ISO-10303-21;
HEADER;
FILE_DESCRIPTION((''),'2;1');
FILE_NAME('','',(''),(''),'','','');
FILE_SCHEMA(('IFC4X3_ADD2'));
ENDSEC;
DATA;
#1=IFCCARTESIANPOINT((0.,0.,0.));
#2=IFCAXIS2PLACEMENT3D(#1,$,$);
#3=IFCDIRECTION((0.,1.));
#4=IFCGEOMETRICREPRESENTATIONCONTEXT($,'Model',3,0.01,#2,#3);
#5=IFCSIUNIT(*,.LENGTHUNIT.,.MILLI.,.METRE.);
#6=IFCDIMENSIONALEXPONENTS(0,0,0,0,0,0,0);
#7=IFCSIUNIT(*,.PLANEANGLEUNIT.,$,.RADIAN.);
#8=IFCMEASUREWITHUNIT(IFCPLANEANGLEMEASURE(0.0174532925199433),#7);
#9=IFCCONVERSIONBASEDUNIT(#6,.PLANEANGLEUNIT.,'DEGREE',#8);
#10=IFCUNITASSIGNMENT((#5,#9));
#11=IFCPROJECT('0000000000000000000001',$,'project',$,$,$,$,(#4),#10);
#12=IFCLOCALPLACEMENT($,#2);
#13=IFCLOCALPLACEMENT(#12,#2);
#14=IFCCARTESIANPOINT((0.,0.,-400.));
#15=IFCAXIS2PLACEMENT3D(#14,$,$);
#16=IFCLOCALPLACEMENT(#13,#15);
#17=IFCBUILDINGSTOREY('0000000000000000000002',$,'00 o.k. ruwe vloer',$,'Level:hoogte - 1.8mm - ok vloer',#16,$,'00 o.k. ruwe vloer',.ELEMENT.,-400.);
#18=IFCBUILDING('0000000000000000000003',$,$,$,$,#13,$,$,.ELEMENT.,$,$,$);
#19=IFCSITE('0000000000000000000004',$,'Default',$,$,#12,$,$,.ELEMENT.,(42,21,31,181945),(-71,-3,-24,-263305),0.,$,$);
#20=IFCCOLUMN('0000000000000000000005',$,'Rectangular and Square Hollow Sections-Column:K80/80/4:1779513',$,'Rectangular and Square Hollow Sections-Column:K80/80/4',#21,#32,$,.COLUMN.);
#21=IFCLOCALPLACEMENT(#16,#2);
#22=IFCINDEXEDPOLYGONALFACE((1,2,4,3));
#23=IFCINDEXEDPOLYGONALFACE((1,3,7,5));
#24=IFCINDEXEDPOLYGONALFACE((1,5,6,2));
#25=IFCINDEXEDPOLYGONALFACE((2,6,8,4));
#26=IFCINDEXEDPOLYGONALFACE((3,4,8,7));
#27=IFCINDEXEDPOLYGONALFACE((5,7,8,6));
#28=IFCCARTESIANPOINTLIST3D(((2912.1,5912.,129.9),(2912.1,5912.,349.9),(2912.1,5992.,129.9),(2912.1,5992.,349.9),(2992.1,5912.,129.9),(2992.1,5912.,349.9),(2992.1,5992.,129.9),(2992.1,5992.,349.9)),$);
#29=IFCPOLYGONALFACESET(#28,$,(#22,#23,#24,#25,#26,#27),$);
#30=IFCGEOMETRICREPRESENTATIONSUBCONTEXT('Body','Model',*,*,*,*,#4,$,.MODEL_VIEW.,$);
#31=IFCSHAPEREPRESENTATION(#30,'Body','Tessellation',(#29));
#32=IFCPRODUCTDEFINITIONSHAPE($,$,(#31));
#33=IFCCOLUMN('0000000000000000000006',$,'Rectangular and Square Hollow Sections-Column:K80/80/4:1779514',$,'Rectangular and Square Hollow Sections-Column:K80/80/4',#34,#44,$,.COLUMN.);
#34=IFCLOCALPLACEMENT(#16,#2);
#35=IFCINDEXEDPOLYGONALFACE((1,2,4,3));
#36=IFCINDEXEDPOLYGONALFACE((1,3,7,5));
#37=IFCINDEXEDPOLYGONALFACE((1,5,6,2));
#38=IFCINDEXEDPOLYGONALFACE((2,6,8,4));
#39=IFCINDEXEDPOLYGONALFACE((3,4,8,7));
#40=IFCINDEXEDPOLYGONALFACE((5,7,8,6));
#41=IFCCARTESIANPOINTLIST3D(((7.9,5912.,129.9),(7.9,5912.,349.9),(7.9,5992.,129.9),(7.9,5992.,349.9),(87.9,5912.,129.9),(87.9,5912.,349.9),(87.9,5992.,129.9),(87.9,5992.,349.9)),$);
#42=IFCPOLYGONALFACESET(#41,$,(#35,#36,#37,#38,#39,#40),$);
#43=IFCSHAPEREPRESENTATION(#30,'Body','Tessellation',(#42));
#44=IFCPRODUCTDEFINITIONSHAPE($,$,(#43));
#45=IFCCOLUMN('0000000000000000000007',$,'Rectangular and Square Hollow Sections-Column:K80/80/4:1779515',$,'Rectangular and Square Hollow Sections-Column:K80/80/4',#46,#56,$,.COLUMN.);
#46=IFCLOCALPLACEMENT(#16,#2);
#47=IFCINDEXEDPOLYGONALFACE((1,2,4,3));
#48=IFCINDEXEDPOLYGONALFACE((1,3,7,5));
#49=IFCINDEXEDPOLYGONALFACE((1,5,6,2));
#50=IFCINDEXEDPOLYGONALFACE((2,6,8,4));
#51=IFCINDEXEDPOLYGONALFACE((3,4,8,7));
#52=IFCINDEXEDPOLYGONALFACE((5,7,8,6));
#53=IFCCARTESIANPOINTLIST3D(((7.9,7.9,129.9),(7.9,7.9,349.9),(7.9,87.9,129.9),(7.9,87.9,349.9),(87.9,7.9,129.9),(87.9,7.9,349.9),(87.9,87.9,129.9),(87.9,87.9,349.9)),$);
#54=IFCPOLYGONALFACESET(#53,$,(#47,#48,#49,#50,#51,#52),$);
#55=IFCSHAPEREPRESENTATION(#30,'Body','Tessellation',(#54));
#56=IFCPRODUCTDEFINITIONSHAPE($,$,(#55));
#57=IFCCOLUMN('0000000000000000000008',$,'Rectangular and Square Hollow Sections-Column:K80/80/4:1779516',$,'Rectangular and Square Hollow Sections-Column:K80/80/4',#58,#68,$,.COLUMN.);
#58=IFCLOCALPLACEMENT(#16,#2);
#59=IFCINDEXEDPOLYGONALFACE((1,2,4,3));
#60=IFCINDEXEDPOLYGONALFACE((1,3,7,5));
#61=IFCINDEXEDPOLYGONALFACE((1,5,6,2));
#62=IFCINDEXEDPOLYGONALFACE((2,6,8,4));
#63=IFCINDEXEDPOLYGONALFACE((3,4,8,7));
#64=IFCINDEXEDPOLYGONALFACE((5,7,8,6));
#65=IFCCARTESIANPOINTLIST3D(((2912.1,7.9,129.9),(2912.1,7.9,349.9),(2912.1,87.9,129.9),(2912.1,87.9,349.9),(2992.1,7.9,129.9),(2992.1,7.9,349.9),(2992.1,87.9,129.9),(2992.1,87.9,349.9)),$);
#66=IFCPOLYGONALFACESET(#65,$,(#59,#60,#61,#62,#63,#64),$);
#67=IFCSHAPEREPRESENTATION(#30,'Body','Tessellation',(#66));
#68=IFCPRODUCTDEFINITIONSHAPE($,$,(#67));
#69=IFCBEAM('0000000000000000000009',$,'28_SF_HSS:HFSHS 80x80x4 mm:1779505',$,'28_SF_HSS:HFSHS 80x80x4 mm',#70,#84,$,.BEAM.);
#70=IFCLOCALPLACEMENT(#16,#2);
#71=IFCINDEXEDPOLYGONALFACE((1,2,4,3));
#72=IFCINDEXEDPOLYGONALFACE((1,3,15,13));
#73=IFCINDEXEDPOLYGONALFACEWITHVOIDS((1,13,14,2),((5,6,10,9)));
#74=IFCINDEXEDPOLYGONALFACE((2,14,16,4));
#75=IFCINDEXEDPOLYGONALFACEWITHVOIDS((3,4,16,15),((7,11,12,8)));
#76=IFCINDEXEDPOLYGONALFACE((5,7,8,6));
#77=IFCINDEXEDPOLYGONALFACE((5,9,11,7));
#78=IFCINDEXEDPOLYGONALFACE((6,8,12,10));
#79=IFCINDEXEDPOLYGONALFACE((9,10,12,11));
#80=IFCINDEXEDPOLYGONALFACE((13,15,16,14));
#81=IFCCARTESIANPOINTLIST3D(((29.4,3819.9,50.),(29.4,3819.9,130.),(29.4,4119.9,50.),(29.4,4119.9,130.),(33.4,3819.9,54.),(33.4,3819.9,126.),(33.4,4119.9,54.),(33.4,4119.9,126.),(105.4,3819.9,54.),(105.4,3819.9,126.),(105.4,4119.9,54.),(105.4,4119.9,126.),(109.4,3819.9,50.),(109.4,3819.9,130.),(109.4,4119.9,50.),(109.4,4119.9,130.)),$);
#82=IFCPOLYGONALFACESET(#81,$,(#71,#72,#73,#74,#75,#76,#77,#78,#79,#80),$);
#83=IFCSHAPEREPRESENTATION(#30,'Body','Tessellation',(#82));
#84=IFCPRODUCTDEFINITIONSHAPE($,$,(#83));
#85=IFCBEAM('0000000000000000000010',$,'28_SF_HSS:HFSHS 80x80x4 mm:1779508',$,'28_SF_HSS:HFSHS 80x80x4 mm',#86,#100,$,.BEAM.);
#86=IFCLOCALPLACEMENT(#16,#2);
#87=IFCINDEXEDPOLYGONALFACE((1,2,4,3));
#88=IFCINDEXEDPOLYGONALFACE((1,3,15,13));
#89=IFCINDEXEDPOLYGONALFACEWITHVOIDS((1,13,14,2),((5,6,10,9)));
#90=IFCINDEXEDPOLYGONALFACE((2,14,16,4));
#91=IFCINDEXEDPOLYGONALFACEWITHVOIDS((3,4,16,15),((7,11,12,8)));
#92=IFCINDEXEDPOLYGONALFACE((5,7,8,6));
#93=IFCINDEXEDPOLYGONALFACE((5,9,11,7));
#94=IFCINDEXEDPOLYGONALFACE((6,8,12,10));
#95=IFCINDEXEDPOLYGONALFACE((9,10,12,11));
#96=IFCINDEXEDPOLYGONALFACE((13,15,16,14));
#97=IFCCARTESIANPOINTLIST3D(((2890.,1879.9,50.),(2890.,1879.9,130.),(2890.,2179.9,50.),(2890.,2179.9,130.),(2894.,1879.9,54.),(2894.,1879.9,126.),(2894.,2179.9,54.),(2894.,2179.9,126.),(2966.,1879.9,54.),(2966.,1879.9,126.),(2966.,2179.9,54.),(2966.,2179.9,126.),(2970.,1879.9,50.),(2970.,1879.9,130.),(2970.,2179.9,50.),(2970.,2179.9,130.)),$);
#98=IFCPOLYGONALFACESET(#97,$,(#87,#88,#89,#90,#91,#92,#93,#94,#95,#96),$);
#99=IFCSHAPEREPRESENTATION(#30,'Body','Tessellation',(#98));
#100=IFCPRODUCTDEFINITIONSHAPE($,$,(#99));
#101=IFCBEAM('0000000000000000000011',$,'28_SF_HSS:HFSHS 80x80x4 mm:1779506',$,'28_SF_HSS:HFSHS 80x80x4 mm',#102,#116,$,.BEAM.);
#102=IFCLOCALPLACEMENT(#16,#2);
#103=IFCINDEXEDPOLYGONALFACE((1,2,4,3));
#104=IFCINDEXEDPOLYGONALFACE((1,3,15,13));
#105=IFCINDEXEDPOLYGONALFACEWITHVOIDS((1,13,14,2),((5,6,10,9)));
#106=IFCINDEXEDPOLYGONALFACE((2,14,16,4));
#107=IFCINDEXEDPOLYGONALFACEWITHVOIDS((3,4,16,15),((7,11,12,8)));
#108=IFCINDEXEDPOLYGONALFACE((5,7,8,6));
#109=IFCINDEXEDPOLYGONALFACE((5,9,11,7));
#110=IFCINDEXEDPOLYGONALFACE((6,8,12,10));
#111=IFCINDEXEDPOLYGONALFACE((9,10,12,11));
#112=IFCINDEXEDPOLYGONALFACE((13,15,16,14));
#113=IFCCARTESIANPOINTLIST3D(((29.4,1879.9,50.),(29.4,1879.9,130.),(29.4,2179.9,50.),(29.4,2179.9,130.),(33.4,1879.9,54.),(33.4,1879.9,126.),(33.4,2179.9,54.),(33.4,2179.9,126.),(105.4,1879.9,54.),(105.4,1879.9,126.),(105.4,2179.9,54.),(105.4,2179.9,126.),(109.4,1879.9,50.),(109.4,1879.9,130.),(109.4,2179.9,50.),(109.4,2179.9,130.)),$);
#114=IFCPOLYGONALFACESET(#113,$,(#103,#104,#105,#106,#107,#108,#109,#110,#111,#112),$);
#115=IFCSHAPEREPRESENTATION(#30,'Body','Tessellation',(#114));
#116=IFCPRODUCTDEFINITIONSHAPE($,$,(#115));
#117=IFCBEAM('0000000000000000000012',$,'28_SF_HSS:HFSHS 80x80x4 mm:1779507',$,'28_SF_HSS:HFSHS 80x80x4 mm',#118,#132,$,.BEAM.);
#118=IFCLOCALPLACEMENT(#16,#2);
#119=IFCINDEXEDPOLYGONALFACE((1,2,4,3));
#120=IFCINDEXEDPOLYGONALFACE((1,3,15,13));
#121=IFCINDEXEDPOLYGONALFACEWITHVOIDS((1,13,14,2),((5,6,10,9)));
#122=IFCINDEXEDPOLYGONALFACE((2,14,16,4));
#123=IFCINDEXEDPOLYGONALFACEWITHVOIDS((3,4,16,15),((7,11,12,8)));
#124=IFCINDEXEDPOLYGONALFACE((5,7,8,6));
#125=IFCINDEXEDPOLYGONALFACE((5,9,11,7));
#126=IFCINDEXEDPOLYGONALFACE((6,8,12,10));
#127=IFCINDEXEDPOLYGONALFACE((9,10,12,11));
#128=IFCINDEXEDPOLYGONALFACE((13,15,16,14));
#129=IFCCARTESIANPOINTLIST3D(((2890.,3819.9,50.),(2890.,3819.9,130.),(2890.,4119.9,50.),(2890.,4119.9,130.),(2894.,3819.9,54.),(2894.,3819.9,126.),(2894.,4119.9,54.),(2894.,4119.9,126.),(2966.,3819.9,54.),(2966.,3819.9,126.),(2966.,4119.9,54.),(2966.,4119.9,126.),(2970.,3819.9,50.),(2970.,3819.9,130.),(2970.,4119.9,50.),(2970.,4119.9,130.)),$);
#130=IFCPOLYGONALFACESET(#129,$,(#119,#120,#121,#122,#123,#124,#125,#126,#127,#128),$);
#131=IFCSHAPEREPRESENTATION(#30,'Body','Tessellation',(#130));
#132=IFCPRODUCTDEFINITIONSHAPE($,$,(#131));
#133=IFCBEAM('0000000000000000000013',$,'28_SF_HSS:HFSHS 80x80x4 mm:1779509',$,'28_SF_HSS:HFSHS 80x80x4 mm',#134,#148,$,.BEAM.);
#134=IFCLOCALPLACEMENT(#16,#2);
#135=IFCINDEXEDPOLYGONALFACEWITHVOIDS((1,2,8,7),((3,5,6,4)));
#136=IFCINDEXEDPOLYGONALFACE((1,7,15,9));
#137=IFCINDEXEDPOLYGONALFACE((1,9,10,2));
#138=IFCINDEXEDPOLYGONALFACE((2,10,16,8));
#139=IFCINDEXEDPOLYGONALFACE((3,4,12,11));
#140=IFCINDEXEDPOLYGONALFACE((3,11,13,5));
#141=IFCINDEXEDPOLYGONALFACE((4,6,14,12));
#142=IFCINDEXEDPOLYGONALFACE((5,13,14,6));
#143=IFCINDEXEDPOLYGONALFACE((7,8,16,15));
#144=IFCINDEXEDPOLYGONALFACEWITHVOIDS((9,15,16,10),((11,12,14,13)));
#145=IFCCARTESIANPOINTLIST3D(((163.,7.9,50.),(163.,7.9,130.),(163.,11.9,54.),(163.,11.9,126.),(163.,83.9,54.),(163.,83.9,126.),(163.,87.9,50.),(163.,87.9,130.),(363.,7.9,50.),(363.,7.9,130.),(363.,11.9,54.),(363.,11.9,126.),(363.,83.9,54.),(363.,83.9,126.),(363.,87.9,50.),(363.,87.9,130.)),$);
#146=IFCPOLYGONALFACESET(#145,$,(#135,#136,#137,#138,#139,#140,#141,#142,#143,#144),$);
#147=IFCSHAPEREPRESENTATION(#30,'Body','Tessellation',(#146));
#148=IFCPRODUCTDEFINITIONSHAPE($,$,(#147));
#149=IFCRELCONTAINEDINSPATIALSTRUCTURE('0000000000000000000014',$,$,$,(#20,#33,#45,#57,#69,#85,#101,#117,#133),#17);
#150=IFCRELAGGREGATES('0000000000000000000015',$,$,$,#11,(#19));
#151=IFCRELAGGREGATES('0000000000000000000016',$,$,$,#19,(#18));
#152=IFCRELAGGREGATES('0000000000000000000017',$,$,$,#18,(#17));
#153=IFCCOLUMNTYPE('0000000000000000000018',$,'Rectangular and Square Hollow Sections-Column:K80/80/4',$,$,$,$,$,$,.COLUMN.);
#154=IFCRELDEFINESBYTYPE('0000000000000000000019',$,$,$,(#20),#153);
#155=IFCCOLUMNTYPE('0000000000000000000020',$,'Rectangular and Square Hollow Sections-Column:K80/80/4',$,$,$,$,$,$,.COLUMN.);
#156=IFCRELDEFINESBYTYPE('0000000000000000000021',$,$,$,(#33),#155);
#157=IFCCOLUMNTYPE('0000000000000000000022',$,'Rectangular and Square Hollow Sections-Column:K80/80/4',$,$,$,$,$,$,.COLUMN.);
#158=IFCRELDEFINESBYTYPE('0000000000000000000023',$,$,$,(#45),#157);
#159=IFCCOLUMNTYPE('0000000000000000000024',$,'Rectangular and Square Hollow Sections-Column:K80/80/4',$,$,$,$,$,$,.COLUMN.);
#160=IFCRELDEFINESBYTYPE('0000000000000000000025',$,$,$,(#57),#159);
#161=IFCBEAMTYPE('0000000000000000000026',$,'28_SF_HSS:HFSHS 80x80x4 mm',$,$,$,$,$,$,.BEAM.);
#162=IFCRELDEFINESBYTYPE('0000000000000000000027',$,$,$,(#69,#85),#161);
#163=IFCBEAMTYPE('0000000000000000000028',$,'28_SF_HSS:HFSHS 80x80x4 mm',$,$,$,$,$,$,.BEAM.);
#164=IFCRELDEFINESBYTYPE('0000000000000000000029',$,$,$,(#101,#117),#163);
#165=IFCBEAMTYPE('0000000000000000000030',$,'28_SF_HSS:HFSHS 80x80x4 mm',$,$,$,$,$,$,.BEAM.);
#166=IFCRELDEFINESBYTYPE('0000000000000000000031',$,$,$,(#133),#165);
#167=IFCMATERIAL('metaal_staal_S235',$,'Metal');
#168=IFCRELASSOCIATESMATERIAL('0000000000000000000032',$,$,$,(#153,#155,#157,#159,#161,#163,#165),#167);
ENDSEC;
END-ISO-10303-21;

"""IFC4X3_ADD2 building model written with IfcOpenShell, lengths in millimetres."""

from ifc_helpers import new_model, entity, si_unit, converted_unit, direction, frame, frame_2d, origin, origin_2d_with_axis, place, context, subcontext, project, spatial, polyline, rectangle, outline, extrude, source, transform, mapped, material, material_profile, profile_set, type_object, type_shapes, element, save


model = new_model("IFC4X3_ADD2")

# Units and contexts
model_context = context("Model", 3, precision=0.01, world=origin(), true_north=direction((0.0, 1.0)))
body_context = subcontext(model_context, "Body", "Model", "MODEL_VIEW")
ifc_project = project(units=[si_unit("LENGTHUNIT", "METRE", prefix="MILLI"), converted_unit("PLANEANGLEUNIT", "DEGREE", entity("IfcPlaneAngleMeasure", 0.0174532925199433), si_unit("PLANEANGLEUNIT", "RADIAN"), dimensions=[0, 0, 0, 0, 0, 0, 0])], contexts=[model_context])

# Site, building, storey
site_placement = place(None, origin())
site = spatial("IfcSite", under=ifc_project, at=site_placement, Name="Default", CompositionType="ELEMENT", RefLatitude=(42, 21, 31, 181945), RefLongitude=(-71, -3, -24, -263305), RefElevation=0.0)
building_placement = place(site_placement, origin())
building = spatial("IfcBuilding", under=site, at=building_placement, CompositionType="ELEMENT")
storey_placement = place(building_placement, frame((0.0, 0.0, -400.0)))
storey = spatial("IfcBuildingStorey", under=building, at=storey_placement, Name="00 o.k. ruwe vloer", ObjectType="Level:hoogte - 1.8mm - ok vloer", LongName="00 o.k. ruwe vloer", CompositionType="ELEMENT", Elevation=-400.0)

# Columns, openings
ifc_material = material(Name="metaal_staal_S235", Category="Metal")
ifc_material_profile_1 = material_profile(ifc_material, rectangle(XDim=220.0, YDim=80.0, at=frame_2d((0.0, 0.0), x_axis=(1.0, 0.0))), Name="K80/80/4")
ifc_profile_set_1 = profile_set([ifc_material_profile_1], Name="K80/80/4")
column_type_1 = type_object("IfcColumnType", Name="Rectangular and Square Hollow Sections-Column:K80/80/4", PredefinedType="COLUMN", material=ifc_profile_set_1)
shared_shape_1 = source(origin(), body_context, "Body", "SweptSolid", [
    extrude(rectangle(XDim=220.0, YDim=80.0, at=frame_2d((0.0, 0.0), x_axis=(1.0, 0.0))), frame((0.0, 40.0, 110.0), z_axis=(1.0, 0.0, 0.0), x_axis=(0.0, 0.0, -1.0)), (0.0, 0.0, 1.0), 80.0),
])
type_shapes(column_type_1, [shared_shape_1])
column_1_placement = place(storey_placement, frame((2912.1, 5912.0, 129.9)))
column_1 = element("IfcColumn", 1, at=column_1_placement, inside=storey, type_object=column_type_1, Name="Rectangular and Square Hollow Sections-Column:K80/80/4:1779513", ObjectType="Rectangular and Square Hollow Sections-Column:K80/80/4", PredefinedType="COLUMN", context=body_context, shape_type="MappedRepresentation", body=[
    mapped(shared_shape_1, transform((0.0, 0.0, 0.0), scale=1.0)),
])
opening_1_placement = place(storey_placement, frame((2912.1, 5912.0, 129.9)))
element("IfcOpeningElement", 2, at=opening_1_placement, cuts=column_1, PredefinedType="OPENING", context=body_context, shape_type="SweptSolid", body=[
    extrude(rectangle(XDim=72.0, YDim=72.0, at=frame_2d((0.0, 0.0), x_axis=(1.0, 0.0))), frame((40.0, 40.0, 620.0), z_axis=(0.0, 0.0, -1.0), x_axis=(0.0, -1.0, 0.0)), (0.0, 0.0, 1.0), 220.0),
])
column_type_2 = type_object("IfcColumnType", Name="Rectangular and Square Hollow Sections-Column:K80/80/4", PredefinedType="COLUMN", material=ifc_profile_set_1)
shared_shape_2 = source(origin(), body_context, "Body", "SweptSolid", [
    extrude(rectangle(XDim=220.0, YDim=80.0, at=frame_2d((0.0, 0.0), x_axis=(0.0, 1.0))), frame((0.0, 40.0, 110.0), z_axis=(1.0, 0.0, 0.0), x_axis=(0.0, -1.0, 0.0)), (0.0, 0.0, 1.0), 80.0),
])
type_shapes(column_type_2, [shared_shape_2])
column_2_placement = place(storey_placement, frame((7.9, 5912.0, 129.9)))
column_2 = element("IfcColumn", 3, at=column_2_placement, inside=storey, type_object=column_type_2, Name="Rectangular and Square Hollow Sections-Column:K80/80/4:1779514", ObjectType="Rectangular and Square Hollow Sections-Column:K80/80/4", PredefinedType="COLUMN", context=body_context, shape_type="MappedRepresentation", body=[
    mapped(shared_shape_2, transform((0.0, 0.0, 0.0), scale=1.0)),
])
opening_2_placement = place(storey_placement, frame((7.9, 5912.0, 129.9)))
element("IfcOpeningElement", 4, at=opening_2_placement, cuts=column_2, PredefinedType="OPENING", context=body_context, shape_type="SweptSolid", body=[
    extrude(rectangle(XDim=72.0, YDim=72.0, at=frame_2d((0.0, 0.0), x_axis=(1.0, 0.0))), frame((40.0, 40.0, 620.0), z_axis=(0.0, 0.0, -1.0), x_axis=(1.0, 0.0, 0.0)), (0.0, 0.0, 1.0), 220.0),
])
column_type_3 = type_object("IfcColumnType", Name="Rectangular and Square Hollow Sections-Column:K80/80/4", PredefinedType="COLUMN", material=ifc_profile_set_1)
shared_shape_3 = source(origin(), body_context, "Body", "SweptSolid", [
    extrude(rectangle(XDim=220.0, YDim=80.0, at=origin_2d_with_axis()), frame((0.0, 40.0, 110.0), z_axis=(1.0, 0.0, 0.0), x_axis=(0.0, 0.0, -1.0)), (0.0, 0.0, 1.0), 80.0),
])
type_shapes(column_type_3, [shared_shape_3])
column_3_placement = place(storey_placement, frame((7.9, 7.9, 129.9)))
column_3 = element("IfcColumn", 5, at=column_3_placement, inside=storey, type_object=column_type_3, Name="Rectangular and Square Hollow Sections-Column:K80/80/4:1779515", ObjectType="Rectangular and Square Hollow Sections-Column:K80/80/4", PredefinedType="COLUMN", context=body_context, shape_type="MappedRepresentation", body=[
    mapped(shared_shape_3, transform((0.0, 0.0, 0.0), scale=1.0)),
])
opening_3_placement = place(storey_placement, frame((7.9, 7.9, 129.9)))
element("IfcOpeningElement", 6, at=opening_3_placement, cuts=column_3, PredefinedType="OPENING", context=body_context, shape_type="SweptSolid", body=[
    extrude(rectangle(XDim=72.0, YDim=72.0, at=frame_2d((0.0, 0.0), x_axis=(1.0, 0.0))), frame((40.0, 40.0, 620.0), z_axis=(0.0, 0.0, -1.0), x_axis=(0.0, 1.0, 0.0)), (0.0, 0.0, 1.0), 220.0),
])
column_type_4 = type_object("IfcColumnType", Name="Rectangular and Square Hollow Sections-Column:K80/80/4", PredefinedType="COLUMN", material=ifc_profile_set_1)
shared_shape_4 = source(origin(), body_context, "Body", "SweptSolid", [
    extrude(rectangle(XDim=220.0, YDim=80.0, at=frame_2d((0.0, 0.0), x_axis=(0.0, 1.0))), frame((0.0, 40.0, 110.0), z_axis=(1.0, 0.0, 0.0), x_axis=(0.0, -1.0, 0.0)), (0.0, 0.0, 1.0), 80.0),
])
type_shapes(column_type_4, [shared_shape_4])
column_4_placement = place(storey_placement, frame((2912.1, 7.9, 129.9)))
column_4 = element("IfcColumn", 7, at=column_4_placement, inside=storey, type_object=column_type_4, Name="Rectangular and Square Hollow Sections-Column:K80/80/4:1779516", ObjectType="Rectangular and Square Hollow Sections-Column:K80/80/4", PredefinedType="COLUMN", context=body_context, shape_type="MappedRepresentation", body=[
    mapped(shared_shape_4, transform((0.0, 0.0, 0.0), scale=1.0)),
])
opening_4_placement = place(storey_placement, frame((2912.1, 7.9, 129.9)))
element("IfcOpeningElement", 8, at=opening_4_placement, cuts=column_4, PredefinedType="OPENING", context=body_context, shape_type="SweptSolid", body=[
    extrude(rectangle(XDim=72.0, YDim=72.0, at=frame_2d((0.0, 0.0), x_axis=(1.0, 0.0))), frame((40.0, 40.0, 400.0), z_axis=(0.0, 0.0, 1.0), x_axis=(0.0, 1.0, 0.0)), (0.0, 0.0, 1.0), 220.0),
])

# Beams
ifc_material_profile_2 = material_profile(ifc_material, outline(polyline([(-40.0, -40.0), (40.0, -40.0), (40.0, 40.0), (-40.0, 40.0), (-40.0, -40.0)]), holes=[polyline([(-36.0, -36.0), (-36.0, 36.0), (36.0, 36.0), (36.0, -36.0), (-36.0, -36.0)])]), Name="HFSHS 80x80x4 mm")
ifc_profile_set_2 = profile_set([ifc_material_profile_2], Name="HFSHS 80x80x4 mm")
beam_type_1 = type_object("IfcBeamType", Name="28_SF_HSS:HFSHS 80x80x4 mm", PredefinedType="BEAM", material=ifc_profile_set_2)
shared_shape_5 = source(origin(), body_context, "Body", "SweptSolid", [
    extrude(outline(polyline([(-40.0, -40.0), (40.0, -40.0), (40.0, 40.0), (-40.0, 40.0), (-40.0, -40.0)]), holes=[polyline([(-36.0, -36.0), (-36.0, 36.0), (36.0, 36.0), (36.0, -36.0), (-36.0, -36.0)])]), frame((-150.0, 0.0, 0.0), z_axis=(1.0, 0.0, 0.0), x_axis=(0.0, -1.0, 0.0)), (0.0, 0.0, 1.0), 300.0),
])
type_shapes(beam_type_1, [shared_shape_5])
for number, where, z_axis, x_axis, name in (
    (9, (69.4, 3969.9, 90.0), (0.0, 0.0, 1.0), (0.0, 1.0, 0.0), "28_SF_HSS:HFSHS 80x80x4 mm:1779505"),
    (10, (2930.0, 2029.9, 90.0), (0.0, 0.0, 1.0), (0.0, -1.0, 0.0), "28_SF_HSS:HFSHS 80x80x4 mm:1779508"),
):
    element("IfcBeam", number, at=place(storey_placement, frame(where, z_axis=z_axis, x_axis=x_axis)), inside=storey, type_object=beam_type_1, Name=name, ObjectType="28_SF_HSS:HFSHS 80x80x4 mm", PredefinedType="BEAM", context=body_context, shape_type="MappedRepresentation", body=[
        mapped(shared_shape_5, transform((0.0, 0.0, 0.0), scale=1.0)),
    ])
beam_type_2 = type_object("IfcBeamType", Name="28_SF_HSS:HFSHS 80x80x4 mm", PredefinedType="BEAM", material=ifc_profile_set_2)
shared_shape_6 = source(origin(), body_context, "Body", "SweptSolid", [
    extrude(outline(polyline([(-40.0, -40.0), (40.0, -40.0), (40.0, 40.0), (-40.0, 40.0), (-40.0, -40.0)]), holes=[polyline([(-36.0, -36.0), (-36.0, 36.0), (36.0, 36.0), (36.0, -36.0), (-36.0, -36.0)])]), frame((-150.0, 0.0, 0.0), z_axis=(1.0, 0.0, 0.0), x_axis=(0.0, 0.0, -1.0)), (0.0, 0.0, 1.0), 300.0),
])
type_shapes(beam_type_2, [shared_shape_6])
for number, where, z_axis, x_axis, name in (
    (11, (69.4, 2029.9, 90.0), (0.0, 0.0, 1.0), (0.0, -1.0, 0.0), "28_SF_HSS:HFSHS 80x80x4 mm:1779506"),
    (12, (2930.0, 3969.9, 90.0), (0.0, 0.0, 1.0), (0.0, 1.0, 0.0), "28_SF_HSS:HFSHS 80x80x4 mm:1779507"),
):
    element("IfcBeam", number, at=place(storey_placement, frame(where, z_axis=z_axis, x_axis=x_axis)), inside=storey, type_object=beam_type_2, Name=name, ObjectType="28_SF_HSS:HFSHS 80x80x4 mm", PredefinedType="BEAM", context=body_context, shape_type="MappedRepresentation", body=[
        mapped(shared_shape_6, transform((0.0, 0.0, 0.0), scale=1.0)),
    ])
beam_type_3 = type_object("IfcBeamType", Name="28_SF_HSS:HFSHS 80x80x4 mm", PredefinedType="BEAM", material=ifc_profile_set_2)
shared_shape_7 = source(origin(), body_context, "Body", "SweptSolid", [
    extrude(outline(polyline([(-40.0, -40.0), (40.0, -40.0), (40.0, 40.0), (-40.0, 40.0), (-40.0, -40.0)]), holes=[polyline([(-36.0, -36.0), (-36.0, 36.0), (36.0, 36.0), (36.0, -36.0), (-36.0, -36.0)])]), frame((-100.0, 0.0, 0.0), z_axis=(1.0, 0.0, 0.0), x_axis=(0.0, -1.0, 0.0)), (0.0, 0.0, 1.0), 200.0),
])
type_shapes(beam_type_3, [shared_shape_7])
beam_1_placement = place(storey_placement, frame((263.0, 47.9, 90.0), z_axis=(0.0, 0.0, 1.0), x_axis=(-1.0, 0.0, 0.0)))
element("IfcBeam", 13, at=beam_1_placement, inside=storey, type_object=beam_type_3, Name="28_SF_HSS:HFSHS 80x80x4 mm:1779509", ObjectType="28_SF_HSS:HFSHS 80x80x4 mm", PredefinedType="BEAM", context=body_context, shape_type="MappedRepresentation", body=[
    mapped(shared_shape_7, transform((0.0, 0.0, 0.0), scale=1.0)),
])

save(model, "model.ifc")
